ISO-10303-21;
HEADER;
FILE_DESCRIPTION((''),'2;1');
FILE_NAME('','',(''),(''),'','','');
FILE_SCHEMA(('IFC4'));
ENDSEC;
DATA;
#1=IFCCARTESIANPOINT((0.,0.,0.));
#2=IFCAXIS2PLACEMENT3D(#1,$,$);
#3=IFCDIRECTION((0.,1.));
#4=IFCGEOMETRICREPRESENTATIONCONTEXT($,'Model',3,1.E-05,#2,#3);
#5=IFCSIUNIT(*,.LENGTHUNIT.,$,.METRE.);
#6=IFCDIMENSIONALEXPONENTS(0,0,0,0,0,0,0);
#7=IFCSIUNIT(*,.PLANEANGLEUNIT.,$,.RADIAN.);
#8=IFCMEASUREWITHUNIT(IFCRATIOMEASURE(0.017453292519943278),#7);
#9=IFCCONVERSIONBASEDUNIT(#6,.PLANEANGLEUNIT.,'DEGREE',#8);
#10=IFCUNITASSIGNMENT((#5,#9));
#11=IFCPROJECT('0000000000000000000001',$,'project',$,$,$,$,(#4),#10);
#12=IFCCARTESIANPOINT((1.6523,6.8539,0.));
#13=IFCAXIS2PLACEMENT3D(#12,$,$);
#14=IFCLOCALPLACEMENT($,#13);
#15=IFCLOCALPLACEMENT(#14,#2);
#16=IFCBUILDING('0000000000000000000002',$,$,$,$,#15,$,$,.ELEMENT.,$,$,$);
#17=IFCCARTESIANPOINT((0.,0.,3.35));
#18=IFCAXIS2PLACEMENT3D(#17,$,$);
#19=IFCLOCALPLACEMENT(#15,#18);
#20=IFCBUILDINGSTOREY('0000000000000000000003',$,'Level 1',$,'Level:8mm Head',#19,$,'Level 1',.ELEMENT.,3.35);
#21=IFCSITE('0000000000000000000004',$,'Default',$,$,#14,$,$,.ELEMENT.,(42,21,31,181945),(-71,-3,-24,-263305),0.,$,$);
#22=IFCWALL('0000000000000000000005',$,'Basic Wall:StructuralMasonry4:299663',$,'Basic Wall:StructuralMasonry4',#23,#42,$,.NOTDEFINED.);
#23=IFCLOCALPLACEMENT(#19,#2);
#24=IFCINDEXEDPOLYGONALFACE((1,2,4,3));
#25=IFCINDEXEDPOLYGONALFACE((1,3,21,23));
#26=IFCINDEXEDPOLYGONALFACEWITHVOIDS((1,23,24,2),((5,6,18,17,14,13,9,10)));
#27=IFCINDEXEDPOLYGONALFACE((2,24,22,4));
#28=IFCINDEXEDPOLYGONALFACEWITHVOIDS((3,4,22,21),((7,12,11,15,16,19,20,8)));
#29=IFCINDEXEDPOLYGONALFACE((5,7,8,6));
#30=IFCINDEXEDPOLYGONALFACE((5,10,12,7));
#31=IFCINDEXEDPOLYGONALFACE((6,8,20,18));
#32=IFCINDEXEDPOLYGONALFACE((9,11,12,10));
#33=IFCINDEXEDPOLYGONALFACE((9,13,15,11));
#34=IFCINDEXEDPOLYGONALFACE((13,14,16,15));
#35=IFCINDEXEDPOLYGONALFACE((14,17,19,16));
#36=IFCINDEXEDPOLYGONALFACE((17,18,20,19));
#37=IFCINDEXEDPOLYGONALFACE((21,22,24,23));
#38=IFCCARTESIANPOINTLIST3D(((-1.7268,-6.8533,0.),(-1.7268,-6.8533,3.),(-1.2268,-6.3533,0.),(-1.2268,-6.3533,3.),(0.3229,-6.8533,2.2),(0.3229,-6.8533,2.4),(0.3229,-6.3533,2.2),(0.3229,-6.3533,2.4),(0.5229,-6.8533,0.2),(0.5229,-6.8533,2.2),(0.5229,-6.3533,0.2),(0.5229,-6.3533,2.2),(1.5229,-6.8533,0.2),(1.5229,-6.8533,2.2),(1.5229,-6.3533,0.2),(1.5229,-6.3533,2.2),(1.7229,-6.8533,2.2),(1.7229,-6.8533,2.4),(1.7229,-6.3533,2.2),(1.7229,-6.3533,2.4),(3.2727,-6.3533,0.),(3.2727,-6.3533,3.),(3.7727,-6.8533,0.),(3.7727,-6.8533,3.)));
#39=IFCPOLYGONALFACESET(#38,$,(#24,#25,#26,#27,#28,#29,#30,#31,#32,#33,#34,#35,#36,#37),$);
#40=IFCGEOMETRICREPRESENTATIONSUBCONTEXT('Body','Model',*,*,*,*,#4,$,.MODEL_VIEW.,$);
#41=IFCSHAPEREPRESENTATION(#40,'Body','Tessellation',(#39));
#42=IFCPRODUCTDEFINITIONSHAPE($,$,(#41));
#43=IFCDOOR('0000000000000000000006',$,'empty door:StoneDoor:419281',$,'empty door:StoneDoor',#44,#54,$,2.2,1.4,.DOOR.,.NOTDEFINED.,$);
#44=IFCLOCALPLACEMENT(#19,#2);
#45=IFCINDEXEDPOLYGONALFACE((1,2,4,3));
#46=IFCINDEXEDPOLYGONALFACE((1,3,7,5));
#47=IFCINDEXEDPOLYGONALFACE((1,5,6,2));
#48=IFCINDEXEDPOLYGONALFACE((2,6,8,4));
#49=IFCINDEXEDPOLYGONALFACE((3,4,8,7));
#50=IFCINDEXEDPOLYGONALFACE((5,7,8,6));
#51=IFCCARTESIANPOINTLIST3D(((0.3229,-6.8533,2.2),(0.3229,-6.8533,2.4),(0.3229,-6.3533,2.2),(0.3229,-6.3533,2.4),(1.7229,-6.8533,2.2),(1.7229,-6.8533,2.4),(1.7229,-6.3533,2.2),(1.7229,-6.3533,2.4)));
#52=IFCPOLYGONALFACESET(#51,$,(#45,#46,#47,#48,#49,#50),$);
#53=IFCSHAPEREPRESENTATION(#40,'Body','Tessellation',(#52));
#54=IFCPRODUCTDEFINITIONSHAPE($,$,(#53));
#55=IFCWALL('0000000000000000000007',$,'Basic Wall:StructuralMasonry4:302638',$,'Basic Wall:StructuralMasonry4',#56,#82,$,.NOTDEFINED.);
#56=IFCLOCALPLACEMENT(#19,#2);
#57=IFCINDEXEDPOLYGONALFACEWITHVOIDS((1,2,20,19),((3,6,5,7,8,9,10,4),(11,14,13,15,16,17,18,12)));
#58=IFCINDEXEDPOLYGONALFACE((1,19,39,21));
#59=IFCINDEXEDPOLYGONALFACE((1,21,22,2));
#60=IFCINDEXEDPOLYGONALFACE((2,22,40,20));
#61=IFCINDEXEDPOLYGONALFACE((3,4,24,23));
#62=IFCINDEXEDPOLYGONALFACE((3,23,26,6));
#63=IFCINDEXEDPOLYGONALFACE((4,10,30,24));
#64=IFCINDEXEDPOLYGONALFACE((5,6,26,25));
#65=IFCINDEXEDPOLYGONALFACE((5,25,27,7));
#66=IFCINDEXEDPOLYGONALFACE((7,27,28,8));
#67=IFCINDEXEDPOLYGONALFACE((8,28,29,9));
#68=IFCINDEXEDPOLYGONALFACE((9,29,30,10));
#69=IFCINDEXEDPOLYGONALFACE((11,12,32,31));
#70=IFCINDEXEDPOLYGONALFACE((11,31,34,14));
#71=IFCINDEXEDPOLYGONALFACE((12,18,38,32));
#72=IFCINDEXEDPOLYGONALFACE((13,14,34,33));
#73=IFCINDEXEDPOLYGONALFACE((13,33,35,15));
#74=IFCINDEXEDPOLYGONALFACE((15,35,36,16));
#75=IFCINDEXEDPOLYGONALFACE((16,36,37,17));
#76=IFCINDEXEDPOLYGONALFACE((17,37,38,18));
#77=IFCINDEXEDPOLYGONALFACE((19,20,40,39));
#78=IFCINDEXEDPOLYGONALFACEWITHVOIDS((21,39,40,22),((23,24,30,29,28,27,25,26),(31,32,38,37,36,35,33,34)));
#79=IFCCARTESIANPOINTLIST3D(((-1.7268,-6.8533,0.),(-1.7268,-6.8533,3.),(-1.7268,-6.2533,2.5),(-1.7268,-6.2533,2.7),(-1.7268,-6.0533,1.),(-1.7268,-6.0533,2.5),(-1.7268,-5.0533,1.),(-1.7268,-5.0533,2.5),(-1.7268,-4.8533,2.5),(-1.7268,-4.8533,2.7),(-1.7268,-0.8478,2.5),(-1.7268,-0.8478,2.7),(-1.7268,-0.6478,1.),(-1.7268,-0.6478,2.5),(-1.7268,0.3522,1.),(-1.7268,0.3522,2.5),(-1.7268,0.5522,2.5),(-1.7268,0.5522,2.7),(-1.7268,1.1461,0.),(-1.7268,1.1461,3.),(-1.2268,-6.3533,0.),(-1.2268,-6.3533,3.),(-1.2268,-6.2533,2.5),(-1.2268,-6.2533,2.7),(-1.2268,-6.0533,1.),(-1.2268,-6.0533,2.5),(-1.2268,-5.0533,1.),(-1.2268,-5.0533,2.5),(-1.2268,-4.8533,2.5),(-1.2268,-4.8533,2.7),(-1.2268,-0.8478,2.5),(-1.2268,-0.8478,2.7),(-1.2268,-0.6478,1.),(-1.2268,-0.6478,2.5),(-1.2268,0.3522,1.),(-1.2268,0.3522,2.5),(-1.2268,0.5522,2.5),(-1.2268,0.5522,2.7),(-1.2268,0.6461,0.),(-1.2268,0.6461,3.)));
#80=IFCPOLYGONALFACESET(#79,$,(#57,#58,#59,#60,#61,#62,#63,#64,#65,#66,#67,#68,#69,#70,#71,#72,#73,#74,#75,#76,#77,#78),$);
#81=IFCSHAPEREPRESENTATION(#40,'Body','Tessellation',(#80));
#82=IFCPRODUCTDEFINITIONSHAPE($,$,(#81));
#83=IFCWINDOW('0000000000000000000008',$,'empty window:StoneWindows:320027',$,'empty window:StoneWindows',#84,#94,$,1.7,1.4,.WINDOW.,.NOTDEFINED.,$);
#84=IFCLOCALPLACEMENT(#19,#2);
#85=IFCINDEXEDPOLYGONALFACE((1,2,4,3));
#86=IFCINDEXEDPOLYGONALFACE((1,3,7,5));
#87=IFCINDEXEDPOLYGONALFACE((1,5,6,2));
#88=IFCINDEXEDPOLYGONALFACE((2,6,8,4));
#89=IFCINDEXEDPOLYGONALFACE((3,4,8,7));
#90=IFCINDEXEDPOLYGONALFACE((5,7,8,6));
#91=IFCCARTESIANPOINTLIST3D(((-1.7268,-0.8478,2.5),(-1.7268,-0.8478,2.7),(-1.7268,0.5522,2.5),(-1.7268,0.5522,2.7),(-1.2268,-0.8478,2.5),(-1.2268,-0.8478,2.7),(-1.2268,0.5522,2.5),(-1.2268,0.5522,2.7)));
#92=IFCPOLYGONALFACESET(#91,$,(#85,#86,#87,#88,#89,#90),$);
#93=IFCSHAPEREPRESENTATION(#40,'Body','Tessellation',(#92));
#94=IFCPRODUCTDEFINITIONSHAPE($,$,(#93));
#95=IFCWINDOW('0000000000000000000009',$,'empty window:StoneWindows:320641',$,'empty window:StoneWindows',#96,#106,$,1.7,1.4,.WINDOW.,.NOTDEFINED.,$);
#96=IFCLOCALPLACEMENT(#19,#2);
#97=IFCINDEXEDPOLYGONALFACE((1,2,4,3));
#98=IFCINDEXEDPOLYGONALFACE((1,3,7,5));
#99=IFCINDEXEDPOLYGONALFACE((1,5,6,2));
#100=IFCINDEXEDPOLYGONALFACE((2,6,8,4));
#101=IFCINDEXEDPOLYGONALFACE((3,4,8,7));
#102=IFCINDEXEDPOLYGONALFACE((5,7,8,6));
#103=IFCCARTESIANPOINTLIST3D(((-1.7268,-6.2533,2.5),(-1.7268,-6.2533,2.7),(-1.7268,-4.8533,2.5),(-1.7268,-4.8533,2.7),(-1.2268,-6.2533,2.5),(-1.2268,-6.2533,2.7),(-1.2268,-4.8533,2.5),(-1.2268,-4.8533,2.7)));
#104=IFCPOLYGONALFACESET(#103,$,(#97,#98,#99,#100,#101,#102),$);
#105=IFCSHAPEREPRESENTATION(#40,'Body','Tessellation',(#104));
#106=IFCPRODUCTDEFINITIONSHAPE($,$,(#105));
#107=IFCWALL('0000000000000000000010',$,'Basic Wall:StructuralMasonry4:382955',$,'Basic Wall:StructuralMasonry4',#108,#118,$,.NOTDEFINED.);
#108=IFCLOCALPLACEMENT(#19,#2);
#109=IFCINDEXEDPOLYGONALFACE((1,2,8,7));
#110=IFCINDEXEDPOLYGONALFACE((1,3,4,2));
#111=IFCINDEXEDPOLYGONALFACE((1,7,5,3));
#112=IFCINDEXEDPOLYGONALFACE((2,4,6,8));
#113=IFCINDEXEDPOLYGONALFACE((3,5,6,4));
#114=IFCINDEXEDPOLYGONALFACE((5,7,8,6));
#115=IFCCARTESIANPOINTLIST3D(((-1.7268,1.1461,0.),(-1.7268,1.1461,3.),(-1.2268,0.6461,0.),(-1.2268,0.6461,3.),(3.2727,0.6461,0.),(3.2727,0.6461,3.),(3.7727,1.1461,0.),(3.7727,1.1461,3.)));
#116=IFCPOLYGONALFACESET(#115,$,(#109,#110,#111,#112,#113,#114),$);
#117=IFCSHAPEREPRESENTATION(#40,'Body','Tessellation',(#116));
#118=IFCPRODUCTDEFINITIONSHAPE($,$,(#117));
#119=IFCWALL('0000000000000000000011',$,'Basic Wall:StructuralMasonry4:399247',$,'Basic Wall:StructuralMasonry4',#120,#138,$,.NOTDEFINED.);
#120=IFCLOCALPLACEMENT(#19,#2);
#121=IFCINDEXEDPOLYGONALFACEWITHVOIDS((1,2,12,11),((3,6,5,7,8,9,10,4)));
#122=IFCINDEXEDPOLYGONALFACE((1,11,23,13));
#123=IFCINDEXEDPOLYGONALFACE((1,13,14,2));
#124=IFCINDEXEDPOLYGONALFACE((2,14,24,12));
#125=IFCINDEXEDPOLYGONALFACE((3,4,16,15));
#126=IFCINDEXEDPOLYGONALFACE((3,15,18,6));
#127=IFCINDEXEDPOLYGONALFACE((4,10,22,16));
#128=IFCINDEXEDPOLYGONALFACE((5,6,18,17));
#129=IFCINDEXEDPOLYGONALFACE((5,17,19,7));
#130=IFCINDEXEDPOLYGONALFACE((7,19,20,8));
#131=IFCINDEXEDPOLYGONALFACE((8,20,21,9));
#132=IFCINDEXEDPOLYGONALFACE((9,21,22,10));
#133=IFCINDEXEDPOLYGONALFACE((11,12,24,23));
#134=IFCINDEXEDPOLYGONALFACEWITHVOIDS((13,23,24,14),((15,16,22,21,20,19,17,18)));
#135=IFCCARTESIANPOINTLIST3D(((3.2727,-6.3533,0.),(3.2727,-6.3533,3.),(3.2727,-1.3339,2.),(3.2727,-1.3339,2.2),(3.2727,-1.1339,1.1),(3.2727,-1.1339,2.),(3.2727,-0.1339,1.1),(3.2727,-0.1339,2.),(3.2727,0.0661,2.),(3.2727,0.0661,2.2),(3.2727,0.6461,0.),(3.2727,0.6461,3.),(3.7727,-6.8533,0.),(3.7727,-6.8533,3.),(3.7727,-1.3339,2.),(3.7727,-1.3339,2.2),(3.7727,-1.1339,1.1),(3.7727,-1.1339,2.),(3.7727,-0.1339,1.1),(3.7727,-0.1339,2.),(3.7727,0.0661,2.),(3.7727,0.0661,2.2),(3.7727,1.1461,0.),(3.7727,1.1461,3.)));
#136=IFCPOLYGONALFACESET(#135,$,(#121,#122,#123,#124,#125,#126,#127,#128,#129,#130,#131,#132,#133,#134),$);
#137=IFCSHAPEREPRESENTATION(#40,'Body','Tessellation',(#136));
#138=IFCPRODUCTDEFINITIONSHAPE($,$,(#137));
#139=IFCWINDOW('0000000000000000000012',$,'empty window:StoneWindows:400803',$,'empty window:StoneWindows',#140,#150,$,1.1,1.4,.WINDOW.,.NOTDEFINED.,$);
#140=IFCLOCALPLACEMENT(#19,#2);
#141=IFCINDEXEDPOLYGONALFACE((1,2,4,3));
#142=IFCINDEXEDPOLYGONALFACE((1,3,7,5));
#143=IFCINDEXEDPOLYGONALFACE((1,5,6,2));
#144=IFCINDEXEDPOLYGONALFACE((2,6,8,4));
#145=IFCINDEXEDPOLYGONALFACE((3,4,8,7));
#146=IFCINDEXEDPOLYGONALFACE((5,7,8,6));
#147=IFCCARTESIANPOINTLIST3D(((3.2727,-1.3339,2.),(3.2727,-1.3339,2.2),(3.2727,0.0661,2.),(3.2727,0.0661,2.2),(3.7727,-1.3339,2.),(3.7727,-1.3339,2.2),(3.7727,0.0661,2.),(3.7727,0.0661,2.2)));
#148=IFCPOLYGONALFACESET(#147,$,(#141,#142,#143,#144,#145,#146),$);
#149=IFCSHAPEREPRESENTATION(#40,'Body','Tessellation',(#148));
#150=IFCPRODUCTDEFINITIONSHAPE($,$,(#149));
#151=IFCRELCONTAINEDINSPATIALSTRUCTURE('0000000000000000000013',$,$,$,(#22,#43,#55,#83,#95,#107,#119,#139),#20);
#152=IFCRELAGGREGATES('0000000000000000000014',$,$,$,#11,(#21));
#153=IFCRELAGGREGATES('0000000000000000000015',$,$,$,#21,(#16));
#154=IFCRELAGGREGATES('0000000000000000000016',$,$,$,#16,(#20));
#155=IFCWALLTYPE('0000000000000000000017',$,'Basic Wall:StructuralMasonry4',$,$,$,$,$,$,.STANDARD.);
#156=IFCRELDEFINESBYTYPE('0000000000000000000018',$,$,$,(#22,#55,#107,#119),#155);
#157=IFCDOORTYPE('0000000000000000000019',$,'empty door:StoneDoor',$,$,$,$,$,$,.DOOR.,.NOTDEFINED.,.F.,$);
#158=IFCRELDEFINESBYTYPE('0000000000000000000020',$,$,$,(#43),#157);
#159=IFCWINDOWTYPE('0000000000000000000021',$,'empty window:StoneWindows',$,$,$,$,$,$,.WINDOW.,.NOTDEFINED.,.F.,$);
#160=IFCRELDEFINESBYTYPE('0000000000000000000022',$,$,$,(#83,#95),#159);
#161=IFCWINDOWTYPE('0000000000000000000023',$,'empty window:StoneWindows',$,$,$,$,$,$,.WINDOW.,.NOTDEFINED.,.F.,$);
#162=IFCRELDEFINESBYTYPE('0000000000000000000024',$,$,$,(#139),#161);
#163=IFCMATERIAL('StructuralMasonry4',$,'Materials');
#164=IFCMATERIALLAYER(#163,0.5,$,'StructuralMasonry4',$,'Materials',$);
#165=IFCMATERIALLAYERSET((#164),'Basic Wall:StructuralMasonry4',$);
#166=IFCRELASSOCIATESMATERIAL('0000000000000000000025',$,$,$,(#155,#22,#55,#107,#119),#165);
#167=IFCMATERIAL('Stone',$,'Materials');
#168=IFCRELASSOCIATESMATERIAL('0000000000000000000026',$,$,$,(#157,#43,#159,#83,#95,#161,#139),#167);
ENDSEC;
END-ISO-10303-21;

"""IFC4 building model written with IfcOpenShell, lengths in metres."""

from ifc_helpers import new_model, entity, si_unit, converted_unit, direction, frame, frame_2d, origin, origin_2d_with_axis, place, context, subcontext, project, spatial, polyline, rectangle, outline, extrude, source, transform, mapped, material, layer, layer_set, layer_usage, type_object, type_shapes, element, fill, save


model = new_model("IFC4")

# Units and contexts
model_context = context("Model", 3, precision=1e-05, world=origin(), true_north=direction((0.0, 1.0)))
body_context = subcontext(model_context, "Body", "Model", "MODEL_VIEW")
ifc_project = project(units=[si_unit("LENGTHUNIT", "METRE"), converted_unit("PLANEANGLEUNIT", "DEGREE", entity("IfcRatioMeasure", 0.017453292519943278), si_unit("PLANEANGLEUNIT", "RADIAN"), dimensions=[0, 0, 0, 0, 0, 0, 0])], contexts=[model_context])

# Site, building, storey
site_placement = place(None, frame((1.6523, 6.8539, 0.0)))
site = spatial("IfcSite", under=ifc_project, at=site_placement, Name="Default", CompositionType="ELEMENT", RefLatitude=(42, 21, 31, 181945), RefLongitude=(-71, -3, -24, -263305), RefElevation=0.0)
building_placement = place(site_placement, origin())
building = spatial("IfcBuilding", under=site, at=building_placement, CompositionType="ELEMENT")
storey_placement = place(building_placement, frame((0.0, 0.0, 3.35)))
storey = spatial("IfcBuildingStorey", under=building, at=storey_placement, Name="Level 1", ObjectType="Level:8mm Head", LongName="Level 1", CompositionType="ELEMENT", Elevation=3.35)

# Wall, opening, door
ifc_material_1 = material(Name="StructuralMasonry4", Category="Materials")
ifc_layer = layer(ifc_material_1, 0.5, Name="StructuralMasonry4", Category="Materials")
ifc_layer_set = layer_set([ifc_layer], Name="Basic Wall:StructuralMasonry4")
ifc_layer_usage_1 = layer_usage(ifc_layer_set, "AXIS2", "POSITIVE", -0.25)
wall_type = type_object("IfcWallType", Name="Basic Wall:StructuralMasonry4", PredefinedType="STANDARD", material=ifc_layer_set)
wall_1_placement = place(storey_placement, frame((-1.7268, -6.6033, 0.0)))
wall_1 = element("IfcWall", 1, at=wall_1_placement, inside=storey, type_object=wall_type, material=ifc_layer_usage_1, Name="Basic Wall:StructuralMasonry4:299663", ObjectType="Basic Wall:StructuralMasonry4", PredefinedType="NOTDEFINED", context=body_context, shape_type="SweptSolid", body=[
    extrude(outline(polyline([(5.4995, -0.25), (4.9995, 0.25), (0.5, 0.25), (0.0, -0.25), (5.4995, -0.25)])), origin(), (0.0, 0.0, 1.0), 3.0),
])
opening_1_placement = place(wall_1_placement, frame((3.4498, 0.25, 0.2)))
opening_1 = element("IfcOpeningElement", 2, at=opening_1_placement, cuts=wall_1, PredefinedType="OPENING", context=body_context, shape_type="SweptSolid", body=[
    extrude(outline(polyline([(0.0, 1.2), (0.0, 0.2), (2.0, 0.2), (2.0, 0.0), (2.2, 0.0), (2.2, 1.4), (2.0, 1.4), (2.0, 1.2), (0.0, 1.2)])), frame((0.0, 0.0, 0.0), z_axis=(0.0, -1.0, 0.0), x_axis=(0.0, 0.0, 1.0)), (0.0, 0.0, 1.0), 0.5),
])
ifc_material_2 = material(Name="Stone", Category="Materials")
door_type = type_object("IfcDoorType", Name="empty door:StoneDoor", OperationType="NOTDEFINED", ParameterTakesPrecedence=False, PredefinedType="DOOR", material=ifc_material_2)
shared_shape_1 = source(origin(), body_context, "Body", "SweptSolid", [
    extrude(rectangle(XDim=0.5, YDim=1.4, at=origin_2d_with_axis()), frame((0.7, 0.25, 2.0), z_axis=(0.0, 0.0, 1.0), x_axis=(0.0, 1.0, 0.0)), (0.0, 0.0, 1.0), 0.2),
])
type_shapes(door_type, [shared_shape_1])
door_placement = place(opening_1_placement, frame((0.0, 0.0, 0.0), z_axis=(0.0, 0.0, 1.0), x_axis=(-1.0, 0.0, 0.0)))
door = element("IfcDoor", 3, at=door_placement, inside=storey, type_object=door_type, material=ifc_material_2, Name="empty door:StoneDoor:419281", ObjectType="empty door:StoneDoor", OperationType="NOTDEFINED", OverallHeight=2.2, OverallWidth=1.4, PredefinedType="DOOR", context=body_context, shape_type="MappedRepresentation", body=[
    mapped(shared_shape_1, transform((0.0, 0.0, 0.0), scale=1.0)),
])
fill(opening_1, door)

# Wall, openings, windows
wall_2_placement = place(storey_placement, frame((-1.4768, 1.1461, 0.0), z_axis=(0.0, 0.0, 1.0), x_axis=(0.0, -1.0, 0.0)))
wall_2 = element("IfcWall", 4, at=wall_2_placement, inside=storey, type_object=wall_type, material=ifc_layer_usage_1, Name="Basic Wall:StructuralMasonry4:302638", ObjectType="Basic Wall:StructuralMasonry4", PredefinedType="NOTDEFINED", context=body_context, shape_type="SweptSolid", body=[
    extrude(outline(polyline([(7.9994, -0.25), (7.4994, 0.25), (0.5, 0.25), (0.0, -0.25), (7.9994, -0.25)])), origin(), (0.0, 0.0, 1.0), 3.0),
])
opening_2_placement = place(wall_2_placement, frame((7.3994, 0.25, 1.0)))
opening_2 = element("IfcOpeningElement", 5, at=opening_2_placement, cuts=wall_2, PredefinedType="OPENING", context=body_context, shape_type="SweptSolid", body=[
    extrude(outline(polyline([(0.0, 0.2), (1.5, 0.2), (1.5, 0.0), (1.7, 0.0), (1.7, 1.4), (1.5, 1.4), (1.5, 1.2), (0.0, 1.2), (0.0, 0.2)])), frame((0.0, 0.0, 0.0), z_axis=(0.0, -1.0, 0.0), x_axis=(0.0, 0.0, 1.0)), (0.0, 0.0, 1.0), 0.5),
])
opening_3_placement = place(wall_2_placement, frame((1.9939, 0.25, 1.0)))
opening_3 = element("IfcOpeningElement", 6, at=opening_3_placement, cuts=wall_2, PredefinedType="OPENING", context=body_context, shape_type="SweptSolid", body=[
    extrude(outline(polyline([(0.0, 0.2), (1.5, 0.2), (1.5, 0.0), (1.7, 0.0), (1.7, 1.4), (1.5, 1.4), (1.5, 1.2), (0.0, 1.2), (0.0, 0.2)])), frame((0.0, 0.0, 0.0), z_axis=(0.0, -1.0, 0.0), x_axis=(0.0, 0.0, 1.0)), (0.0, 0.0, 1.0), 0.5),
])
window_type_1 = type_object("IfcWindowType", Name="empty window:StoneWindows", ParameterTakesPrecedence=False, PartitioningType="NOTDEFINED", PredefinedType="WINDOW", material=ifc_material_2)
shared_shape_2 = source(origin(), body_context, "Body", "SweptSolid", [
    extrude(rectangle(XDim=0.2, YDim=1.4, at=frame_2d((-0.1, 0.02), x_axis=(0.0, 1.0))), frame((0.6, 0.0, 1.58), z_axis=(0.0, 1.0, 0.0), x_axis=(-1.0, 0.0, 0.0)), (0.0, 0.0, 1.0), 0.5),
])
type_shapes(window_type_1, [shared_shape_2])
window_1_placement = place(opening_3_placement, frame((0.0, 0.0, 0.0), z_axis=(0.0, 0.0, 1.0), x_axis=(-1.0, 0.0, 0.0)))
window_1 = element("IfcWindow", 7, at=window_1_placement, inside=storey, type_object=window_type_1, material=ifc_material_2, Name="empty window:StoneWindows:320027", ObjectType="empty window:StoneWindows", OverallHeight=1.7, OverallWidth=1.4, PartitioningType="NOTDEFINED", PredefinedType="WINDOW", context=body_context, shape_type="MappedRepresentation", body=[
    mapped(shared_shape_2, transform((0.0, 0.0, 0.0), scale=1.0)),
])
fill(opening_3, window_1)
window_2_placement = place(opening_2_placement, frame((0.0, 0.0, 0.0), z_axis=(0.0, 0.0, 1.0), x_axis=(-1.0, 0.0, 0.0)))
window_2 = element("IfcWindow", 8, at=window_2_placement, inside=storey, type_object=window_type_1, material=ifc_material_2, Name="empty window:StoneWindows:320641", ObjectType="empty window:StoneWindows", OverallHeight=1.7, OverallWidth=1.4, PartitioningType="NOTDEFINED", PredefinedType="WINDOW", context=body_context, shape_type="MappedRepresentation", body=[
    mapped(shared_shape_2, transform((0.0, 0.0, 0.0), scale=1.0)),
])
fill(opening_2, window_2)

# Wall
ifc_layer_usage_2 = layer_usage(ifc_layer_set, "AXIS2", "NEGATIVE", 0.25)
wall_3_placement = place(storey_placement, frame((-1.7268, 0.8961, 0.0)))
element("IfcWall", 9, at=wall_3_placement, inside=storey, type_object=wall_type, material=ifc_layer_usage_2, Name="Basic Wall:StructuralMasonry4:382955", ObjectType="Basic Wall:StructuralMasonry4", PredefinedType="NOTDEFINED", context=body_context, shape_type="SweptSolid", body=[
    extrude(outline(polyline([(4.9995, -0.25), (5.4995, 0.25), (0.0, 0.25), (0.5, -0.25), (4.9995, -0.25)])), origin(), (0.0, 0.0, 1.0), 3.0),
])

# Wall, opening, window
wall_4_placement = place(storey_placement, frame((3.5227, 1.1461, 0.0), z_axis=(0.0, 0.0, 1.0), x_axis=(0.0, -1.0, 0.0)))
wall_4 = element("IfcWall", 10, at=wall_4_placement, inside=storey, type_object=wall_type, material=ifc_layer_usage_2, Name="Basic Wall:StructuralMasonry4:399247", ObjectType="Basic Wall:StructuralMasonry4", PredefinedType="NOTDEFINED", context=body_context, shape_type="SweptSolid", body=[
    extrude(outline(polyline([(7.4994, -0.25), (7.9994, 0.25), (0.0, 0.25), (0.5, -0.25), (7.4994, -0.25)])), origin(), (0.0, 0.0, 1.0), 3.0),
])
opening_4_placement = place(wall_4_placement, frame((1.08, -0.25, 1.1)))
opening_4 = element("IfcOpeningElement", 11, at=opening_4_placement, cuts=wall_4, PredefinedType="OPENING", context=body_context, shape_type="SweptSolid", body=[
    extrude(outline(polyline([(0.0, 0.2), (0.9, 0.2), (0.9, 0.0), (1.1, 0.0), (1.1, 1.4), (0.9, 1.4), (0.9, 1.2), (0.0, 1.2), (0.0, 0.2)])), frame((0.0, 0.0, 0.0), z_axis=(0.0, 1.0, 0.0), x_axis=(0.0, 0.0, 1.0)), (0.0, 0.0, 1.0), 0.5),
])
window_type_2 = type_object("IfcWindowType", Name="empty window:StoneWindows", ParameterTakesPrecedence=False, PartitioningType="NOTDEFINED", PredefinedType="WINDOW", material=ifc_material_2)
shared_shape_3 = source(origin(), body_context, "Body", "SweptSolid", [
    extrude(rectangle(XDim=0.2, YDim=1.4, at=frame_2d((-0.1, 0.02), x_axis=(0.0, 1.0))), frame((0.6, 0.0, 0.98), z_axis=(0.0, 1.0, 0.0), x_axis=(-1.0, 0.0, 0.0)), (0.0, 0.0, 1.0), 0.5),
])
type_shapes(window_type_2, [shared_shape_3])
window_3_placement = place(opening_4_placement, origin())
window_3 = element("IfcWindow", 12, at=window_3_placement, inside=storey, type_object=window_type_2, material=ifc_material_2, Name="empty window:StoneWindows:400803", ObjectType="empty window:StoneWindows", OverallHeight=1.1, OverallWidth=1.4, PartitioningType="NOTDEFINED", PredefinedType="WINDOW", context=body_context, shape_type="MappedRepresentation", body=[
    mapped(shared_shape_3, transform((0.0, 0.0, 0.0), scale=1.0)),
])
fill(opening_4, window_3)

save(model, "model.ifc")
